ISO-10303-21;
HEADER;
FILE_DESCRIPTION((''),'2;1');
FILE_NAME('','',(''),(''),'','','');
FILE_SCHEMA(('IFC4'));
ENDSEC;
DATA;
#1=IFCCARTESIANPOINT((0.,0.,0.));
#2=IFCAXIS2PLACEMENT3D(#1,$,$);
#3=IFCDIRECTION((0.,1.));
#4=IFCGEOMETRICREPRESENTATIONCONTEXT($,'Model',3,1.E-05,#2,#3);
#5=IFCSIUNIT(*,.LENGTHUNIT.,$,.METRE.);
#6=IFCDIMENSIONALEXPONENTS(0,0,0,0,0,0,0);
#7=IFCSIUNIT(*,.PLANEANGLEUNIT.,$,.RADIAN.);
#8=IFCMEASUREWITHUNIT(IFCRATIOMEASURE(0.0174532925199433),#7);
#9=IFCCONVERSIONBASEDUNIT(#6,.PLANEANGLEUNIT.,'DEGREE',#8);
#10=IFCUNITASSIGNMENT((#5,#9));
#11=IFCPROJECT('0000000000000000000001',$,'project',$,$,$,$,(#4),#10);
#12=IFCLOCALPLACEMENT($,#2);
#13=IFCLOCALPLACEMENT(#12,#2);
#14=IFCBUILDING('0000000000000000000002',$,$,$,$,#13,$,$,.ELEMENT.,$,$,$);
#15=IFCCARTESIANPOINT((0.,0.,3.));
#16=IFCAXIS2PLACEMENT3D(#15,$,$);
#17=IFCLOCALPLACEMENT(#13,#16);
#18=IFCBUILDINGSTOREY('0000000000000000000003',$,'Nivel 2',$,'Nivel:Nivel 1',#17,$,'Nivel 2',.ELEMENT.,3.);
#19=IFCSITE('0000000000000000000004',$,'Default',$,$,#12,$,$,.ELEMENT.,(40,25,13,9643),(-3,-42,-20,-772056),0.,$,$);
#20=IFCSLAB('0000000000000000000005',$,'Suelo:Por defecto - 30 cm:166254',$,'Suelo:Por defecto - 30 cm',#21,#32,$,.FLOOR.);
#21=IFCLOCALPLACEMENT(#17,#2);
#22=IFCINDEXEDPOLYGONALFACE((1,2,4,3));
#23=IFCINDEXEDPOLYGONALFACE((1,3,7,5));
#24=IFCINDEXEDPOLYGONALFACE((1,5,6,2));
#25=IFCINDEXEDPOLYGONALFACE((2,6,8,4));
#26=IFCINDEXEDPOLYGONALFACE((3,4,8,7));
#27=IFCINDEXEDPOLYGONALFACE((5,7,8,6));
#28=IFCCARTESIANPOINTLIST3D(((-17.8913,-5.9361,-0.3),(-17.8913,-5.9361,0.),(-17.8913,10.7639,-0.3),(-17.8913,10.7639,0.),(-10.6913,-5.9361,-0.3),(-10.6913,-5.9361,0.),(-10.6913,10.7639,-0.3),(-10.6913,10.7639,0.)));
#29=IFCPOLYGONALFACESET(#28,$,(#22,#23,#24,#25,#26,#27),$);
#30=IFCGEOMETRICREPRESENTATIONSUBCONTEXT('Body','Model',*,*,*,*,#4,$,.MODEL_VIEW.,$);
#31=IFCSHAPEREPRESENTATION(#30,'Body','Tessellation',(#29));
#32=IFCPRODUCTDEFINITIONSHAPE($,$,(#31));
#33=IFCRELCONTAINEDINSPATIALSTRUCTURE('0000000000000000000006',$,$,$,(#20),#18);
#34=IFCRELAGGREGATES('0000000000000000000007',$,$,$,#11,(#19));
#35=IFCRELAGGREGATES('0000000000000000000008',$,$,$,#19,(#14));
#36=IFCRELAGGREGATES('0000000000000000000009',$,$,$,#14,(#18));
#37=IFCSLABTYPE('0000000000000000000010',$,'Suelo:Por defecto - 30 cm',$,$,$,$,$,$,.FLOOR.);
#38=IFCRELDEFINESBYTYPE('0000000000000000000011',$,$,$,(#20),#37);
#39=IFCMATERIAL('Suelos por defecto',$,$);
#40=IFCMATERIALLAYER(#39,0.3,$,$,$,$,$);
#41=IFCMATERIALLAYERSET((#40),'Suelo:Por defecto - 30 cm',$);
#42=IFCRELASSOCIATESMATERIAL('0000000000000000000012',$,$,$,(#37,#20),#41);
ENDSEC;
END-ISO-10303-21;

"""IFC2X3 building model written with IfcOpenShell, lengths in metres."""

from ifc_helpers import new_model, entity, si_unit, converted_unit, direction, frame, origin, origin_2d_with_axis, place, context, subcontext, project, spatial, rectangle, extrude, material, layer, layer_set, layer_usage, type_object, element, save


model = new_model("IFC2X3")

# Units and contexts
model_context = context("Model", 3, precision=1e-05, world=origin(), true_north=direction((0.0, 1.0)))
body_context = subcontext(model_context, "Body", "Model", "MODEL_VIEW")
ifc_project = project(units=[si_unit("LENGTHUNIT", "METRE"), converted_unit("PLANEANGLEUNIT", "DEGREE", entity("IfcRatioMeasure", 0.0174532925199433), si_unit("PLANEANGLEUNIT", "RADIAN"), dimensions=[0, 0, 0, 0, 0, 0, 0])], contexts=[model_context])

# Site, building, storey
site_placement = place(None, origin())
site = spatial("IfcSite", under=ifc_project, at=site_placement, Name="Default", CompositionType="ELEMENT", RefLatitude=(40, 25, 13, 9643), RefLongitude=(-3, -42, -20, -772056), RefElevation=0.0)
building_placement = place(site_placement, origin())
building = spatial("IfcBuilding", under=site, at=building_placement, CompositionType="ELEMENT")
storey_placement = place(building_placement, frame((0.0, 0.0, 3.0)))
storey = spatial("IfcBuildingStorey", under=building, at=storey_placement, Name="Nivel 2", ObjectType="Nivel:Nivel 1", LongName="Nivel 2", CompositionType="ELEMENT", Elevation=3.0)

# Slab
ifc_material = material(Name="Suelos por defecto")
ifc_layer = layer(ifc_material, 0.3)
ifc_layer_set = layer_set([ifc_layer], Name="Suelo:Por defecto - 30 cm")
ifc_layer_usage = layer_usage(ifc_layer_set, "AXIS3", "POSITIVE", 0.0)
slab_type = type_object("IfcSlabType", Name="Suelo:Por defecto - 30 cm", PredefinedType="FLOOR", material=ifc_layer_set)
slab_placement = place(storey_placement, origin())
element("IfcSlab", 1, at=slab_placement, inside=storey, type_object=slab_type, material=ifc_layer_usage, Name="Suelo:Por defecto - 30 cm:166254", ObjectType="Suelo:Por defecto - 30 cm", PredefinedType="FLOOR", context=body_context, shape_type="SweptSolid", body=[
    extrude(rectangle(XDim=16.7, YDim=7.2, at=origin_2d_with_axis()), frame((-14.2913, 2.4139, 0.0), z_axis=(0.0, 0.0, -1.0), x_axis=(0.0, 1.0, 0.0)), (0.0, 0.0, 1.0), 0.3),
])

save(model, "model.ifc")
